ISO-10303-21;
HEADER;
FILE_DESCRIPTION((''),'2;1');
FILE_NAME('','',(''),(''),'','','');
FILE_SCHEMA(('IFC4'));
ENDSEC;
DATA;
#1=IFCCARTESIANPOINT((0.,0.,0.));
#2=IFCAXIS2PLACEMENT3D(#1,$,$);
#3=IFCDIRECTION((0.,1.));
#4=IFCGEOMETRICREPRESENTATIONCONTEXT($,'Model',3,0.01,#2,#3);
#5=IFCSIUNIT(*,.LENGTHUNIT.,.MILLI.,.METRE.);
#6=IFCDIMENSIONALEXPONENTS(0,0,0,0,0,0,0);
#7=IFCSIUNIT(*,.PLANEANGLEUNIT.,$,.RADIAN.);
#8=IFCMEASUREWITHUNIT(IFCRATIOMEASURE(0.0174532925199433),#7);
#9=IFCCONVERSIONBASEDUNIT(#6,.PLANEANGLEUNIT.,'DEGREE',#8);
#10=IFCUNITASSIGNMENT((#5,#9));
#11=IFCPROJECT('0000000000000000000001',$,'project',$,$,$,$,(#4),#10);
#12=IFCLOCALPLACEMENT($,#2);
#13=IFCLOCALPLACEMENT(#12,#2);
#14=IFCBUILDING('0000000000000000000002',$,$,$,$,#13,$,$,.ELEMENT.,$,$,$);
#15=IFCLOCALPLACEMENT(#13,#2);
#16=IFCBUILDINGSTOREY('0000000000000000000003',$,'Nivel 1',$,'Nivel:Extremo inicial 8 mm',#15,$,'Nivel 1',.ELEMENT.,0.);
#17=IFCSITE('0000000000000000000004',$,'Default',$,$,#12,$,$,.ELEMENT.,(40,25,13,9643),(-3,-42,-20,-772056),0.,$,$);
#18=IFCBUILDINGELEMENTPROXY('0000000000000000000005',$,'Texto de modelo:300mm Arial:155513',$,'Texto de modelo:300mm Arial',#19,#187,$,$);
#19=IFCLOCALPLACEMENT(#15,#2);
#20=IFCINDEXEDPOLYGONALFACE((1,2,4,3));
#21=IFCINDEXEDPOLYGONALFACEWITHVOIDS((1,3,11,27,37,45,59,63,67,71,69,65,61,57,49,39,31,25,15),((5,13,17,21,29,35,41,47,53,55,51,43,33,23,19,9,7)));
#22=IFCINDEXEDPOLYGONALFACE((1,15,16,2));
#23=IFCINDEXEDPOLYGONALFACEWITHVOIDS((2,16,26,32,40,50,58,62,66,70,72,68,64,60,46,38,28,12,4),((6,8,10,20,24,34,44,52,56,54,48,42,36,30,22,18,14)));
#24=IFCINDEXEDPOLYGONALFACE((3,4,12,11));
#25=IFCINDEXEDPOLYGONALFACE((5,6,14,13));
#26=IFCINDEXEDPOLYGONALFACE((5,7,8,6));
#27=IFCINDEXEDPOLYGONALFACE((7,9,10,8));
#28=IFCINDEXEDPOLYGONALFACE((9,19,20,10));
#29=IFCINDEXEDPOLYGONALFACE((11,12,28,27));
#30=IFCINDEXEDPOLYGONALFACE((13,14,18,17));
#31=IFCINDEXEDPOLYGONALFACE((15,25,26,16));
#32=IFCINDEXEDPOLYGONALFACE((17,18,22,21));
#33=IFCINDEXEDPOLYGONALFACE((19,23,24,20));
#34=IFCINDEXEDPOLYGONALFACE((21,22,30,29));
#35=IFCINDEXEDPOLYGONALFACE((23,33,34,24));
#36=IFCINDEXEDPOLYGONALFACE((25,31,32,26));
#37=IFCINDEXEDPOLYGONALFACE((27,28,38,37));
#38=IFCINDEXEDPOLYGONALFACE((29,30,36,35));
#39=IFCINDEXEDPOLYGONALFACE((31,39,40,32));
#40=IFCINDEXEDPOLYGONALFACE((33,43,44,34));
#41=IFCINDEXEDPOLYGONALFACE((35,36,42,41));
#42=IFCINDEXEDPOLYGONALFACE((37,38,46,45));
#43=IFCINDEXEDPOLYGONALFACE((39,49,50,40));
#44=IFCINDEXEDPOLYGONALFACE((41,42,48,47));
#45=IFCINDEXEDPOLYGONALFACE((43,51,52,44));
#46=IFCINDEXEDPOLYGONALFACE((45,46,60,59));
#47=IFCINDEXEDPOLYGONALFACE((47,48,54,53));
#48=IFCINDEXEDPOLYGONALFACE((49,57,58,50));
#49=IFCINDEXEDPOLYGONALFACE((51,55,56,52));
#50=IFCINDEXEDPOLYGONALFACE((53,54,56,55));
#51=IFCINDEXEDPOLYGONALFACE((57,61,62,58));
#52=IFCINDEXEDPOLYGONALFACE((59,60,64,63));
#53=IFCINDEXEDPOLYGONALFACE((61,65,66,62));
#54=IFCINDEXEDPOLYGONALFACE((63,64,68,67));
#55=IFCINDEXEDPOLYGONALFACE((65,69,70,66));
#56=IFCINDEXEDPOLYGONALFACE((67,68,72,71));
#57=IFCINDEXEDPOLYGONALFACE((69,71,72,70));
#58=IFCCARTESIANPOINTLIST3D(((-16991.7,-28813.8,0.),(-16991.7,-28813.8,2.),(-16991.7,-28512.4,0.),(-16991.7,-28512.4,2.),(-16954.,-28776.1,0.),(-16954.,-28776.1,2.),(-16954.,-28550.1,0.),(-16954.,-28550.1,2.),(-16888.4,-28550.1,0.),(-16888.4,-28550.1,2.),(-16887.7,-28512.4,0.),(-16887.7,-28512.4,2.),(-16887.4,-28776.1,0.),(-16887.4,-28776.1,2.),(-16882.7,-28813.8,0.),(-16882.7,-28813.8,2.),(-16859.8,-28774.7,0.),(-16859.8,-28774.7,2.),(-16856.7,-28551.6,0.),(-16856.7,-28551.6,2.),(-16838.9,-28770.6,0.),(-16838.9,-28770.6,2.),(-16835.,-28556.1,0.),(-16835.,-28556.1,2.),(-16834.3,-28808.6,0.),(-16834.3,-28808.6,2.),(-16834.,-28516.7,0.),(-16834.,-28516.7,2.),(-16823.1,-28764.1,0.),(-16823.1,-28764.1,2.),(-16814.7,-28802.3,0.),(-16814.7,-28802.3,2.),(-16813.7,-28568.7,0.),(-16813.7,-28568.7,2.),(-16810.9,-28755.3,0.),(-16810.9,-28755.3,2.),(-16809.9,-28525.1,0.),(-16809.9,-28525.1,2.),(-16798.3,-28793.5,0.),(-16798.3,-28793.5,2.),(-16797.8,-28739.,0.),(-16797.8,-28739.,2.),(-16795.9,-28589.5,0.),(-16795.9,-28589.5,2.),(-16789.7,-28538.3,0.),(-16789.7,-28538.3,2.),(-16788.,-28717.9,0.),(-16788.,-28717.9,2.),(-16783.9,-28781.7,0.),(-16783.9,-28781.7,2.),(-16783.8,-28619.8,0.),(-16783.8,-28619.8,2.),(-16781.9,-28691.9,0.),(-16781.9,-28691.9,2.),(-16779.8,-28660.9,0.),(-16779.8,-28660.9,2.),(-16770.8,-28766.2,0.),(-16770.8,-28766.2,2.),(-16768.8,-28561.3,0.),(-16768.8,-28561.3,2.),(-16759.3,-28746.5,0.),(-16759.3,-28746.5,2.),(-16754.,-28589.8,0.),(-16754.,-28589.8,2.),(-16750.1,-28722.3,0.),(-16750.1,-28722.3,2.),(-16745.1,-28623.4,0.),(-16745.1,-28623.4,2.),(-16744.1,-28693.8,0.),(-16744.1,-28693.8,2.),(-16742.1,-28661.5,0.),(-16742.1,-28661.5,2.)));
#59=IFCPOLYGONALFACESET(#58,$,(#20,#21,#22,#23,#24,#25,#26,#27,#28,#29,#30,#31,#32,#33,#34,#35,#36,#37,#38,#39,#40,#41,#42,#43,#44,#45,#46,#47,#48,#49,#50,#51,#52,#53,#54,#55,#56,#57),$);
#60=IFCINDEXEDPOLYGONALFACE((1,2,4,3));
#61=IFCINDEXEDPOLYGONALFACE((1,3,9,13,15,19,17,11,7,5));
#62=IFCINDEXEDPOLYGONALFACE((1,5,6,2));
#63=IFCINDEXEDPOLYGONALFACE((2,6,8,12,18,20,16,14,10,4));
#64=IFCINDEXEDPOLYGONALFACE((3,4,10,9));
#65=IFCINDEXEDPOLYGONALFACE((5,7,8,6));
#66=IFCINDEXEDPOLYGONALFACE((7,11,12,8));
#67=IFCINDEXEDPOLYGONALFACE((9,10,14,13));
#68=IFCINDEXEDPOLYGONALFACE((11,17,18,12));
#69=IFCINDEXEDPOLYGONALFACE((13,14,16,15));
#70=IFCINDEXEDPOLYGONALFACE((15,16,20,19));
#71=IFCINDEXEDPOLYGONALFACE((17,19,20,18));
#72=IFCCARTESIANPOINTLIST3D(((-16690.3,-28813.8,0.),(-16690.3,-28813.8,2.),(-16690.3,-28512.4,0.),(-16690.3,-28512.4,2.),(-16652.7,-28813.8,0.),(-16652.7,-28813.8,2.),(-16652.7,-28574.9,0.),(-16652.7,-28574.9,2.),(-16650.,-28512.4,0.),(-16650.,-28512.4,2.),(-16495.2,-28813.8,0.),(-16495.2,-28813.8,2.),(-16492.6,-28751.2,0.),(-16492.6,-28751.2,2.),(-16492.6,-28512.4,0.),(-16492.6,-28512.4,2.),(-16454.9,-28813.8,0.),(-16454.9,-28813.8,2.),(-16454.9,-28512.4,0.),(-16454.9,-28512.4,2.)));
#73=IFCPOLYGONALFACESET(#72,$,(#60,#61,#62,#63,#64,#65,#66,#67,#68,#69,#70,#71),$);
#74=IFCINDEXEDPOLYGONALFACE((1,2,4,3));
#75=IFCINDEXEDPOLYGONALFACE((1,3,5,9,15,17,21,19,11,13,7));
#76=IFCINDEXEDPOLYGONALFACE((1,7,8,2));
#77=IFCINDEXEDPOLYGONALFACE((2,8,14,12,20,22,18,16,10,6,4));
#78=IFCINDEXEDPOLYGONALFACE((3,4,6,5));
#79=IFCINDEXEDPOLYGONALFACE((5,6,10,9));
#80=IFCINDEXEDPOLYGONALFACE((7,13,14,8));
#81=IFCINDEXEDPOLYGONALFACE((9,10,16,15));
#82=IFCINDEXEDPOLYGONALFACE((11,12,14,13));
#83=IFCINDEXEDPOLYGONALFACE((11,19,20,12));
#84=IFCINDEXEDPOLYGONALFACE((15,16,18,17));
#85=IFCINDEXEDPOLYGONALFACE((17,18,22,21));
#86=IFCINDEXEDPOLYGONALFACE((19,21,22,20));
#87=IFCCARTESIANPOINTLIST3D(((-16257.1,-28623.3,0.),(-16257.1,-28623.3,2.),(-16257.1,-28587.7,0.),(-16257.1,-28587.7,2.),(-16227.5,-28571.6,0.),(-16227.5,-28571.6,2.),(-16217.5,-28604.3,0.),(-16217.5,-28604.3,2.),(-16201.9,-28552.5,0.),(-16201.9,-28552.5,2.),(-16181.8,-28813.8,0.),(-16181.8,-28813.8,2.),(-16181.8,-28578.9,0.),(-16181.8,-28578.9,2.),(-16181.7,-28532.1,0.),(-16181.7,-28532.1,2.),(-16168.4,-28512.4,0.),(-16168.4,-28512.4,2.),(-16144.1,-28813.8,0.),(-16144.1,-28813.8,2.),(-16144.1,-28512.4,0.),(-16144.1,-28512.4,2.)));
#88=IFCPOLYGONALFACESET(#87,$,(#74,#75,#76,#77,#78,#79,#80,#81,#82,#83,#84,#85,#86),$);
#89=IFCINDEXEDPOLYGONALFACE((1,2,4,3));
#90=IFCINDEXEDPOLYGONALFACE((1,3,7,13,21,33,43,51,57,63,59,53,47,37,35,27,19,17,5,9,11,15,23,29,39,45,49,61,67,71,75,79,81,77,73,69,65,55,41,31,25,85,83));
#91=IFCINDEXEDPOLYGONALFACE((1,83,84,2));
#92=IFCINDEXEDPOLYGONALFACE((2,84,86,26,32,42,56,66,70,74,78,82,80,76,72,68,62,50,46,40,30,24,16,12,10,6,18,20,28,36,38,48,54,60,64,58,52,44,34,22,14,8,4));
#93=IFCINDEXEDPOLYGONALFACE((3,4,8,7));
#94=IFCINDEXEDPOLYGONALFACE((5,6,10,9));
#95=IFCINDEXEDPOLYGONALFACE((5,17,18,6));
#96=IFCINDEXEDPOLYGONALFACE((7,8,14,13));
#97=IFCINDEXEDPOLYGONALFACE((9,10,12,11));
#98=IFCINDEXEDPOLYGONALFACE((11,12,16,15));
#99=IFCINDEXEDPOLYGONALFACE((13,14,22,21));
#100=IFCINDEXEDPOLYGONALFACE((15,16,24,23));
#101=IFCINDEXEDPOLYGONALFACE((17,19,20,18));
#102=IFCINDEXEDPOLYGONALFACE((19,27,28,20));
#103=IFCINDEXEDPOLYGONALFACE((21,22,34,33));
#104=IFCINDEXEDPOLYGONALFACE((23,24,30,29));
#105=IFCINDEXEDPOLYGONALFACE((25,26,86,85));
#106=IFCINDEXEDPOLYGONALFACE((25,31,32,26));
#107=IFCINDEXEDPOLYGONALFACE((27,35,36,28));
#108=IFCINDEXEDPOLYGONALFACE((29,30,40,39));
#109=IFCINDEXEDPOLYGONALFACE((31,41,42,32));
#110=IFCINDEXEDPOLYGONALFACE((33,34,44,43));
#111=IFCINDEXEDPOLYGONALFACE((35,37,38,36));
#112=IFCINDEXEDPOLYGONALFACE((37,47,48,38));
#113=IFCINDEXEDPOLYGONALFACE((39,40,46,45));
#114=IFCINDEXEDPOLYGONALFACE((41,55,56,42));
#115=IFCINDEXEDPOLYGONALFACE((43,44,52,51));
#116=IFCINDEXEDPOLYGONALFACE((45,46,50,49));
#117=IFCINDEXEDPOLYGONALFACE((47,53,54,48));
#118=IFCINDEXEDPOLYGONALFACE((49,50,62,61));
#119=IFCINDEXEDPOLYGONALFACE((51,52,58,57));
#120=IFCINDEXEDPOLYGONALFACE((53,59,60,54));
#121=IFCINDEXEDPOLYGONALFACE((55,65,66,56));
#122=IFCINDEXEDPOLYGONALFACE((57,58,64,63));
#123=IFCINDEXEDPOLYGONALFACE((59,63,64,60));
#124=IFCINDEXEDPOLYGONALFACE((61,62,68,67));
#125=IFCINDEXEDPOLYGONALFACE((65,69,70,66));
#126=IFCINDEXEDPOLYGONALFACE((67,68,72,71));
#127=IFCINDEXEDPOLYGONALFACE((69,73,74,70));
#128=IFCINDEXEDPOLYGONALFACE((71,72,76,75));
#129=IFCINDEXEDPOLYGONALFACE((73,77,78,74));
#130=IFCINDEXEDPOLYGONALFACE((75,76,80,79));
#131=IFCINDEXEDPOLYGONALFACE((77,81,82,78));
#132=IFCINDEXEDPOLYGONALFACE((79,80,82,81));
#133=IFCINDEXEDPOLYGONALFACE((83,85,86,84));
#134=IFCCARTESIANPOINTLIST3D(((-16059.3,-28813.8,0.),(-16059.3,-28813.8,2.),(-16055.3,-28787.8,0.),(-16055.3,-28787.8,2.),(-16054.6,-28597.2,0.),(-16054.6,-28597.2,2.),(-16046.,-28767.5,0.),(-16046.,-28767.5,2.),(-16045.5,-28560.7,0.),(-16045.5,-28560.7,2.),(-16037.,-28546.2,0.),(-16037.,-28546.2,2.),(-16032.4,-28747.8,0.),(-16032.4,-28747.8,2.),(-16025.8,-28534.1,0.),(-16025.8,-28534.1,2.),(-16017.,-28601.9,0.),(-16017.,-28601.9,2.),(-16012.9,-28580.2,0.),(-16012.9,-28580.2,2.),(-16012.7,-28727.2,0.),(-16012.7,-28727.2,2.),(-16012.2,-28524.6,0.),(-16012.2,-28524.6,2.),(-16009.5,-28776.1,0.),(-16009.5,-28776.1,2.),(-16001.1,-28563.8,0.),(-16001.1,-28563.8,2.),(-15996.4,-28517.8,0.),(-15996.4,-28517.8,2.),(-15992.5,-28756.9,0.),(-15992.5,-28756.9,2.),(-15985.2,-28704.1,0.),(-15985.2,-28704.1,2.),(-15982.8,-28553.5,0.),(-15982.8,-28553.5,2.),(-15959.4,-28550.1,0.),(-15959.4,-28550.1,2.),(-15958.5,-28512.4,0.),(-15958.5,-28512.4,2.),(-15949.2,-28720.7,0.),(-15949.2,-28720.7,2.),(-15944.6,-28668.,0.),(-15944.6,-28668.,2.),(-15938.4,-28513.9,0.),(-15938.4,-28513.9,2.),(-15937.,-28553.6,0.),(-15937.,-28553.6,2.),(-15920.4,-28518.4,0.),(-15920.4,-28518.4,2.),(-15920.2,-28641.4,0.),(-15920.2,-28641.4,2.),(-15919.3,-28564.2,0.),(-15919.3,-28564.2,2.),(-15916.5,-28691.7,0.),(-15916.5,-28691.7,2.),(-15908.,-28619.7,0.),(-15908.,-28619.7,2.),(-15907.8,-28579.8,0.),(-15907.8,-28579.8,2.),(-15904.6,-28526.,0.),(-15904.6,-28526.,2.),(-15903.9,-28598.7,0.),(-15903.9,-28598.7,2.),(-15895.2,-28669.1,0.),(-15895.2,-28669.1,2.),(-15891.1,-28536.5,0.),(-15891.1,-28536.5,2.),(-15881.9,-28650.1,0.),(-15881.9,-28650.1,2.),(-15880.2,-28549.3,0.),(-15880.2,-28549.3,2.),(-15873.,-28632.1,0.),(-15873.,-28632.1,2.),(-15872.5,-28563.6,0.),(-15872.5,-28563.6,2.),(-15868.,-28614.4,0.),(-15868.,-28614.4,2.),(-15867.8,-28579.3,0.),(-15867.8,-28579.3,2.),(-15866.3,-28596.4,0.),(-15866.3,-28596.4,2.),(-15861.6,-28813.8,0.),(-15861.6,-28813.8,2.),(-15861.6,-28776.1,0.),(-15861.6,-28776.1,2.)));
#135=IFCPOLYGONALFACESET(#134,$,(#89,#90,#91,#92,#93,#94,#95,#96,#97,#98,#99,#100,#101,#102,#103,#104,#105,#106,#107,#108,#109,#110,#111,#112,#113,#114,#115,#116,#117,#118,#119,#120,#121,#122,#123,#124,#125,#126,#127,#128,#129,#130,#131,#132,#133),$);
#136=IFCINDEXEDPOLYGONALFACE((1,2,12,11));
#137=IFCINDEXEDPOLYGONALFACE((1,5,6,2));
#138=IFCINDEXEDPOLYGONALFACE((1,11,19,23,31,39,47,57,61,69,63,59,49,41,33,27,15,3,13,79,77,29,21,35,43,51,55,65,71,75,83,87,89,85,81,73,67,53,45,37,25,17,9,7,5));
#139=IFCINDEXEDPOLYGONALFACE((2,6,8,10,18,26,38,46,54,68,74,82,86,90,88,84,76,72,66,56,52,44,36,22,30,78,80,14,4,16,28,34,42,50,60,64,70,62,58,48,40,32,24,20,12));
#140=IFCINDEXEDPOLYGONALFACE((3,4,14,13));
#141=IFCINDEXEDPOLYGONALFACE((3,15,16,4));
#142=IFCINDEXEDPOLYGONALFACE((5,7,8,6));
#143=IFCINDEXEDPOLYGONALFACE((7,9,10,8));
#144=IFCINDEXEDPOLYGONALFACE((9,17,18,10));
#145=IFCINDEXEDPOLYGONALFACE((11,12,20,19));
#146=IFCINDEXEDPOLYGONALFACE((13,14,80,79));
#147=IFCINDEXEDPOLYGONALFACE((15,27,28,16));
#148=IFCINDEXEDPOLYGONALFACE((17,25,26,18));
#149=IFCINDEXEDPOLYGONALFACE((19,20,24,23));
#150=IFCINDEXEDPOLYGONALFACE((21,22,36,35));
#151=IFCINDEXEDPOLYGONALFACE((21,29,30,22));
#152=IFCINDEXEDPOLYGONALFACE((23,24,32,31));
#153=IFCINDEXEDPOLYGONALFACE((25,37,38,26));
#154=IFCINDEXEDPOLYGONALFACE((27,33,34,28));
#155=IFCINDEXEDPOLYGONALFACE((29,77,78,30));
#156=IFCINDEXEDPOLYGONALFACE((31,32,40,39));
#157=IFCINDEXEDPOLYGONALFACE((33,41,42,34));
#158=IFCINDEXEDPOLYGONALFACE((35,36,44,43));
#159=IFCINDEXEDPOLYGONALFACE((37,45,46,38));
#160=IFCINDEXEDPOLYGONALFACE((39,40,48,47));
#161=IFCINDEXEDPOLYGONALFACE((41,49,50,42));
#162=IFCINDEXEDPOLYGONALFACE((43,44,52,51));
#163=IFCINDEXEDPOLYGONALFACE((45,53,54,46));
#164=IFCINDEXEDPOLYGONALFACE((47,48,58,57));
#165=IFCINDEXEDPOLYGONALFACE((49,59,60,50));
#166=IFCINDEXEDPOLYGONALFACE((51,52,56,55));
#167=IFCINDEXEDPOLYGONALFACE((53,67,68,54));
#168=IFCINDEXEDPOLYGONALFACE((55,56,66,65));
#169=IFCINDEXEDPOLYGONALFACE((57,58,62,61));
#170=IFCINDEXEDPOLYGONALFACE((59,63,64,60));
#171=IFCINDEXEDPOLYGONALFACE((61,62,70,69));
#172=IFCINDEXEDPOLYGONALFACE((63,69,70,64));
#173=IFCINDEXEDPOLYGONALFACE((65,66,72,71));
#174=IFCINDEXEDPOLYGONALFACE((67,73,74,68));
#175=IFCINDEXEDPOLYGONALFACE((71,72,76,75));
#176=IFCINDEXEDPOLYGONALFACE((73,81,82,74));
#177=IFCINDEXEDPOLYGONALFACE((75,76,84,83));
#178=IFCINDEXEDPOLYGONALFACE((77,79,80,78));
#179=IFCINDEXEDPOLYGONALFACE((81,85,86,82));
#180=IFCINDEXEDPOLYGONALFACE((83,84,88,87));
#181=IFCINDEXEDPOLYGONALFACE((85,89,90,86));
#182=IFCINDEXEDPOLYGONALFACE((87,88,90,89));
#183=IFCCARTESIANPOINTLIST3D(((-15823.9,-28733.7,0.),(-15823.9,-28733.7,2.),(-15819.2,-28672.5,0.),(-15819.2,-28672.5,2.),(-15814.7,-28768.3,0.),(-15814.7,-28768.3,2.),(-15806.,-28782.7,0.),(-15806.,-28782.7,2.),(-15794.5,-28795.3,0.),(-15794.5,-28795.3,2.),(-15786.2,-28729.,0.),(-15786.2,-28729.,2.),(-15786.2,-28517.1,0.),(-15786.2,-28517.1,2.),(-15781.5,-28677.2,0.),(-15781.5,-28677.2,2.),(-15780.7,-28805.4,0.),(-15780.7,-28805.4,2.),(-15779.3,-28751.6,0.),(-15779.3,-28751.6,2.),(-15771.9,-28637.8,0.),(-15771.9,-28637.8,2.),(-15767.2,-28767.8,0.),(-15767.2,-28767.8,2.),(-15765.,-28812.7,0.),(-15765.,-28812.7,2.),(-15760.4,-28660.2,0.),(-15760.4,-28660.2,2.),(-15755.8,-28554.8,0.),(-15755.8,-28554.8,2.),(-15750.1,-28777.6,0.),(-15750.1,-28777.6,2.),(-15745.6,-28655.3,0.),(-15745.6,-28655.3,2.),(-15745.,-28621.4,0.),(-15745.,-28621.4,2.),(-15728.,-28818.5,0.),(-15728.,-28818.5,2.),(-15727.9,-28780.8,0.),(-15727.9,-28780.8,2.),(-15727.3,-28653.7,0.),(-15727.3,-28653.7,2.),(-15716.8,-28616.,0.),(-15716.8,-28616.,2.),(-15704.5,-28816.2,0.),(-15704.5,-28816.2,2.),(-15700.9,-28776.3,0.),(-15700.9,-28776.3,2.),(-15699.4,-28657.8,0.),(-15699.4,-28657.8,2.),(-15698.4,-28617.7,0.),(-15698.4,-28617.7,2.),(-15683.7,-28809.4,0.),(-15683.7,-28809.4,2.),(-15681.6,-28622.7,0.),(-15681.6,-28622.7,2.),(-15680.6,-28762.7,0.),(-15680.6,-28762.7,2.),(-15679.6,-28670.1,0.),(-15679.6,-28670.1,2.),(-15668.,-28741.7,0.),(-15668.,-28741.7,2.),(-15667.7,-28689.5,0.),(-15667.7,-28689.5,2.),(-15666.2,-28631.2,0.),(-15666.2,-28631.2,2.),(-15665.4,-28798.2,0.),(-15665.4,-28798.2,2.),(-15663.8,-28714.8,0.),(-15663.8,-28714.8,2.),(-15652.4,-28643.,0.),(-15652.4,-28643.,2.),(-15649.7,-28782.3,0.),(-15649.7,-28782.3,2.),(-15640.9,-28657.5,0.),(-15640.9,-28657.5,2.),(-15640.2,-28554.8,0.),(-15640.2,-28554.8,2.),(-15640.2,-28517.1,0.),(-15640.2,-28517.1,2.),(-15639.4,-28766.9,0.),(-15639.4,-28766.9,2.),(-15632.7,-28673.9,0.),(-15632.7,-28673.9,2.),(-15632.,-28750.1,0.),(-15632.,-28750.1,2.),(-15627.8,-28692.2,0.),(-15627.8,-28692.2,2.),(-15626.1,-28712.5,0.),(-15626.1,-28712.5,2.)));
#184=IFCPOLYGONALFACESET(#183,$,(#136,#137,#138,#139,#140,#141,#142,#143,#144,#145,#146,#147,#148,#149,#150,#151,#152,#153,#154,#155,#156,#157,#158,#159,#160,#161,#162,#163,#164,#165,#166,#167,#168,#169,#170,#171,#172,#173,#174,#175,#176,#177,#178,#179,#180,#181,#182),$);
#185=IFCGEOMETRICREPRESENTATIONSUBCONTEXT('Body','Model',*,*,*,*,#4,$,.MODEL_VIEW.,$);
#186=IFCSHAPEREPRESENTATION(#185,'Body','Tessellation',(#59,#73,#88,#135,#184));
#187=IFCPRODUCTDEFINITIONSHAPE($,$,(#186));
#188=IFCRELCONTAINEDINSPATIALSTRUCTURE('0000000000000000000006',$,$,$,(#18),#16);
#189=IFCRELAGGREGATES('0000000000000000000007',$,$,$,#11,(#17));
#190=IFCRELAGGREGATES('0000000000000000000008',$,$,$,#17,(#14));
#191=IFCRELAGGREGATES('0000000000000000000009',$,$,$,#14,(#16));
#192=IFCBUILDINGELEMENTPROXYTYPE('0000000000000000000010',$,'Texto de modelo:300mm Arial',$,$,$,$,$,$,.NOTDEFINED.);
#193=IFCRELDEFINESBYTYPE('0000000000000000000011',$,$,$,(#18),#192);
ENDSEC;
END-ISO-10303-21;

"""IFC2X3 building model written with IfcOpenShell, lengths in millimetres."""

from ifc_helpers import new_model, entity, si_unit, converted_unit, direction, frame, origin, place, context, subcontext, project, spatial, polyline, outline, extrude, type_object, element, save


model = new_model("IFC2X3")

# Units and contexts
model_context = context("Model", 3, precision=0.01, world=origin(), true_north=direction((0.0, 1.0)))
body_context = subcontext(model_context, "Body", "Model", "MODEL_VIEW")
ifc_project = project(units=[si_unit("LENGTHUNIT", "METRE", prefix="MILLI"), converted_unit("PLANEANGLEUNIT", "DEGREE", entity("IfcRatioMeasure", 0.0174532925199433), si_unit("PLANEANGLEUNIT", "RADIAN"), dimensions=[0, 0, 0, 0, 0, 0, 0])], contexts=[model_context])

# Site, building, storey
site_placement = place(None, origin())
site = spatial("IfcSite", under=ifc_project, at=site_placement, Name="Default", CompositionType="ELEMENT", RefLatitude=(40, 25, 13, 9643), RefLongitude=(-3, -42, -20, -772056), RefElevation=0.0)
building_placement = place(site_placement, origin())
building = spatial("IfcBuilding", under=site, at=building_placement, CompositionType="ELEMENT")
storey_placement = place(building_placement, origin())
storey = spatial("IfcBuildingStorey", under=building, at=storey_placement, Name="Nivel 1", ObjectType="Nivel:Extremo inicial 8 mm", LongName="Nivel 1", CompositionType="ELEMENT", Elevation=0.0)

# Building element proxy
building_element_proxy_type_1 = type_object("IfcBuildingElementProxyType", Name="Texto de modelo:300mm Arial", PredefinedType="NOTDEFINED")
proxy_1_placement = place(storey_placement, frame((-16991.7, -28818.5, 0.0)))
element("IfcBuildingElementProxy", 1, at=proxy_1_placement, inside=storey, type_object=building_element_proxy_type_1, Name="Texto de modelo:300mm Arial:155513", ObjectType="Texto de modelo:300mm Arial", context=body_context, shape_type="SweptSolid", body=[
    extrude(outline(polyline([(-178.4, -141.0), (-69.4, -141.0), (-21.0, -135.8), (-1.4, -129.5), (15.0, -120.7), (29.4, -108.9), (42.6, -93.4), (54.0, -73.7), (63.2, -49.5), (69.2, -21.0), (71.2, 11.3), (68.2, 49.4), (59.3, 83.0), (44.5, 111.5), (23.7, 134.5), (3.4, 147.7), (-20.6, 156.1), (-74.4, 160.4), (-178.4, 160.4), (-178.4, -141.0)]), holes=[polyline([(-140.7, -103.3), (-140.7, 122.7), (-75.1, 122.7), (-43.3, 121.2), (-21.7, 116.7), (-0.4, 104.1), (17.4, 83.3), (29.5, 53.0), (33.5, 11.9), (31.5, -19.1), (25.3, -45.1), (15.5, -66.2), (2.4, -82.5), (-9.8, -91.3), (-25.6, -97.9), (-46.5, -101.9), (-74.1, -103.3), (-140.7, -103.3)])]), frame((178.4, 145.7, 0.0)), (0.0, 0.0, 1.0), 2.0),
    extrude(outline(polyline([(-117.7, -150.7), (-80.1, -150.7), (-80.1, 88.1), (77.4, -150.7), (117.7, -150.7), (117.7, 150.7), (80.1, 150.7), (80.1, -88.1), (-77.4, 150.7), (-117.7, 150.7), (-117.7, -150.7)])), frame((419.1, 155.4, 0.0)), (0.0, 0.0, 1.0), 2.0),
    extrude(outline(polyline([(-204.4, -52.5), (97.0, -52.5), (97.0, -28.2), (77.2, -14.9), (56.9, 5.3), (37.7, 30.9), (21.6, 60.5), (-14.0, 60.5), (5.0, 20.8), (30.4, -14.9), (-204.4, -14.9), (-204.4, -52.5)])), frame((795.1, 209.1, 0.0), z_axis=(0.0, 0.0, 1.0), x_axis=(0.0, 1.0, 0.0)), (0.0, 0.0, 1.0), 2.0),
    extrude(outline(polyline([(-91.6, -150.5), (-91.6, -188.2), (106.2, -188.2), (102.1, -162.2), (92.9, -141.9), (79.3, -122.2), (59.6, -101.6), (32.1, -78.5), (-8.5, -42.4), (-32.9, -15.8), (-45.1, 5.8), (-49.2, 26.9), (-45.4, 45.8), (-33.9, 61.4), (-16.2, 72.0), (6.2, 75.5), (29.7, 72.1), (48.0, 61.8), (59.7, 45.4), (63.8, 23.7), (101.5, 28.4), (92.4, 64.9), (83.8, 79.4), (72.6, 91.5), (59.0, 101.0), (43.3, 107.8), (5.4, 113.2), (-14.8, 111.7), (-32.8, 107.2), (-48.5, 99.6), (-62.0, 89.1), (-72.9, 76.3), (-80.7, 62.0), (-85.3, 46.3), (-86.9, 29.2), (-85.2, 11.2), (-80.2, -6.5), (-71.3, -24.6), (-57.9, -43.5), (-36.6, -66.1), (-3.9, -95.1), (39.4, -131.3), (56.4, -150.5), (-91.6, -150.5)])), frame((1038.6, 192.9, 0.0), z_axis=(0.0, 0.0, -1.0), x_axis=(-1.0, 0.0, 0.0)), (0.0, 0.0, -1.0), 2.0),
    extrude(outline(polyline([(1.4, -113.1), (37.2, -113.1), (53.4, -108.4), (68.5, -100.5), (81.8, -89.8), (92.9, -76.5), (108.0, -42.2), (111.8, -18.9), (110.6, 3.0), (104.4, 23.5), (93.2, 42.7), (80.9, 56.7), (66.6, 68.1), (31.7, 83.5), (11.7, 87.1), (-7.3, 87.1), (-25.2, 83.4), (-42.2, 76.0), (-57.1, 65.7), (-69.2, 53.0), (-78.5, 38.0), (-84.8, 20.7), (-86.8, -7.9), (-77.9, -38.1), (-154.0, -1.2), (-124.3, 110.4), (-160.7, 120.1), (-198.2, -21.0), (-56.5, -92.8), (-42.3, -57.6), (-53.3, -32.8), (-54.2, -17.2), (-51.1, 0.9), (-40.0, 26.8), (-23.0, 42.8), (-1.2, 49.2), (24.3, 46.5), (49.2, 35.5), (66.3, 17.9), (74.2, -5.1), (71.6, -32.4), (62.8, -53.0), (48.9, -67.1), (30.2, -74.6), (6.6, -75.5), (1.4, -113.1)])), frame((1276.7, 115.2, 0.0), z_axis=(0.0, 0.0, 1.0), x_axis=(0.256974, -0.966418, 0.0)), (0.0, 0.0, 1.0), 2.0),
])

save(model, "model.ifc")
